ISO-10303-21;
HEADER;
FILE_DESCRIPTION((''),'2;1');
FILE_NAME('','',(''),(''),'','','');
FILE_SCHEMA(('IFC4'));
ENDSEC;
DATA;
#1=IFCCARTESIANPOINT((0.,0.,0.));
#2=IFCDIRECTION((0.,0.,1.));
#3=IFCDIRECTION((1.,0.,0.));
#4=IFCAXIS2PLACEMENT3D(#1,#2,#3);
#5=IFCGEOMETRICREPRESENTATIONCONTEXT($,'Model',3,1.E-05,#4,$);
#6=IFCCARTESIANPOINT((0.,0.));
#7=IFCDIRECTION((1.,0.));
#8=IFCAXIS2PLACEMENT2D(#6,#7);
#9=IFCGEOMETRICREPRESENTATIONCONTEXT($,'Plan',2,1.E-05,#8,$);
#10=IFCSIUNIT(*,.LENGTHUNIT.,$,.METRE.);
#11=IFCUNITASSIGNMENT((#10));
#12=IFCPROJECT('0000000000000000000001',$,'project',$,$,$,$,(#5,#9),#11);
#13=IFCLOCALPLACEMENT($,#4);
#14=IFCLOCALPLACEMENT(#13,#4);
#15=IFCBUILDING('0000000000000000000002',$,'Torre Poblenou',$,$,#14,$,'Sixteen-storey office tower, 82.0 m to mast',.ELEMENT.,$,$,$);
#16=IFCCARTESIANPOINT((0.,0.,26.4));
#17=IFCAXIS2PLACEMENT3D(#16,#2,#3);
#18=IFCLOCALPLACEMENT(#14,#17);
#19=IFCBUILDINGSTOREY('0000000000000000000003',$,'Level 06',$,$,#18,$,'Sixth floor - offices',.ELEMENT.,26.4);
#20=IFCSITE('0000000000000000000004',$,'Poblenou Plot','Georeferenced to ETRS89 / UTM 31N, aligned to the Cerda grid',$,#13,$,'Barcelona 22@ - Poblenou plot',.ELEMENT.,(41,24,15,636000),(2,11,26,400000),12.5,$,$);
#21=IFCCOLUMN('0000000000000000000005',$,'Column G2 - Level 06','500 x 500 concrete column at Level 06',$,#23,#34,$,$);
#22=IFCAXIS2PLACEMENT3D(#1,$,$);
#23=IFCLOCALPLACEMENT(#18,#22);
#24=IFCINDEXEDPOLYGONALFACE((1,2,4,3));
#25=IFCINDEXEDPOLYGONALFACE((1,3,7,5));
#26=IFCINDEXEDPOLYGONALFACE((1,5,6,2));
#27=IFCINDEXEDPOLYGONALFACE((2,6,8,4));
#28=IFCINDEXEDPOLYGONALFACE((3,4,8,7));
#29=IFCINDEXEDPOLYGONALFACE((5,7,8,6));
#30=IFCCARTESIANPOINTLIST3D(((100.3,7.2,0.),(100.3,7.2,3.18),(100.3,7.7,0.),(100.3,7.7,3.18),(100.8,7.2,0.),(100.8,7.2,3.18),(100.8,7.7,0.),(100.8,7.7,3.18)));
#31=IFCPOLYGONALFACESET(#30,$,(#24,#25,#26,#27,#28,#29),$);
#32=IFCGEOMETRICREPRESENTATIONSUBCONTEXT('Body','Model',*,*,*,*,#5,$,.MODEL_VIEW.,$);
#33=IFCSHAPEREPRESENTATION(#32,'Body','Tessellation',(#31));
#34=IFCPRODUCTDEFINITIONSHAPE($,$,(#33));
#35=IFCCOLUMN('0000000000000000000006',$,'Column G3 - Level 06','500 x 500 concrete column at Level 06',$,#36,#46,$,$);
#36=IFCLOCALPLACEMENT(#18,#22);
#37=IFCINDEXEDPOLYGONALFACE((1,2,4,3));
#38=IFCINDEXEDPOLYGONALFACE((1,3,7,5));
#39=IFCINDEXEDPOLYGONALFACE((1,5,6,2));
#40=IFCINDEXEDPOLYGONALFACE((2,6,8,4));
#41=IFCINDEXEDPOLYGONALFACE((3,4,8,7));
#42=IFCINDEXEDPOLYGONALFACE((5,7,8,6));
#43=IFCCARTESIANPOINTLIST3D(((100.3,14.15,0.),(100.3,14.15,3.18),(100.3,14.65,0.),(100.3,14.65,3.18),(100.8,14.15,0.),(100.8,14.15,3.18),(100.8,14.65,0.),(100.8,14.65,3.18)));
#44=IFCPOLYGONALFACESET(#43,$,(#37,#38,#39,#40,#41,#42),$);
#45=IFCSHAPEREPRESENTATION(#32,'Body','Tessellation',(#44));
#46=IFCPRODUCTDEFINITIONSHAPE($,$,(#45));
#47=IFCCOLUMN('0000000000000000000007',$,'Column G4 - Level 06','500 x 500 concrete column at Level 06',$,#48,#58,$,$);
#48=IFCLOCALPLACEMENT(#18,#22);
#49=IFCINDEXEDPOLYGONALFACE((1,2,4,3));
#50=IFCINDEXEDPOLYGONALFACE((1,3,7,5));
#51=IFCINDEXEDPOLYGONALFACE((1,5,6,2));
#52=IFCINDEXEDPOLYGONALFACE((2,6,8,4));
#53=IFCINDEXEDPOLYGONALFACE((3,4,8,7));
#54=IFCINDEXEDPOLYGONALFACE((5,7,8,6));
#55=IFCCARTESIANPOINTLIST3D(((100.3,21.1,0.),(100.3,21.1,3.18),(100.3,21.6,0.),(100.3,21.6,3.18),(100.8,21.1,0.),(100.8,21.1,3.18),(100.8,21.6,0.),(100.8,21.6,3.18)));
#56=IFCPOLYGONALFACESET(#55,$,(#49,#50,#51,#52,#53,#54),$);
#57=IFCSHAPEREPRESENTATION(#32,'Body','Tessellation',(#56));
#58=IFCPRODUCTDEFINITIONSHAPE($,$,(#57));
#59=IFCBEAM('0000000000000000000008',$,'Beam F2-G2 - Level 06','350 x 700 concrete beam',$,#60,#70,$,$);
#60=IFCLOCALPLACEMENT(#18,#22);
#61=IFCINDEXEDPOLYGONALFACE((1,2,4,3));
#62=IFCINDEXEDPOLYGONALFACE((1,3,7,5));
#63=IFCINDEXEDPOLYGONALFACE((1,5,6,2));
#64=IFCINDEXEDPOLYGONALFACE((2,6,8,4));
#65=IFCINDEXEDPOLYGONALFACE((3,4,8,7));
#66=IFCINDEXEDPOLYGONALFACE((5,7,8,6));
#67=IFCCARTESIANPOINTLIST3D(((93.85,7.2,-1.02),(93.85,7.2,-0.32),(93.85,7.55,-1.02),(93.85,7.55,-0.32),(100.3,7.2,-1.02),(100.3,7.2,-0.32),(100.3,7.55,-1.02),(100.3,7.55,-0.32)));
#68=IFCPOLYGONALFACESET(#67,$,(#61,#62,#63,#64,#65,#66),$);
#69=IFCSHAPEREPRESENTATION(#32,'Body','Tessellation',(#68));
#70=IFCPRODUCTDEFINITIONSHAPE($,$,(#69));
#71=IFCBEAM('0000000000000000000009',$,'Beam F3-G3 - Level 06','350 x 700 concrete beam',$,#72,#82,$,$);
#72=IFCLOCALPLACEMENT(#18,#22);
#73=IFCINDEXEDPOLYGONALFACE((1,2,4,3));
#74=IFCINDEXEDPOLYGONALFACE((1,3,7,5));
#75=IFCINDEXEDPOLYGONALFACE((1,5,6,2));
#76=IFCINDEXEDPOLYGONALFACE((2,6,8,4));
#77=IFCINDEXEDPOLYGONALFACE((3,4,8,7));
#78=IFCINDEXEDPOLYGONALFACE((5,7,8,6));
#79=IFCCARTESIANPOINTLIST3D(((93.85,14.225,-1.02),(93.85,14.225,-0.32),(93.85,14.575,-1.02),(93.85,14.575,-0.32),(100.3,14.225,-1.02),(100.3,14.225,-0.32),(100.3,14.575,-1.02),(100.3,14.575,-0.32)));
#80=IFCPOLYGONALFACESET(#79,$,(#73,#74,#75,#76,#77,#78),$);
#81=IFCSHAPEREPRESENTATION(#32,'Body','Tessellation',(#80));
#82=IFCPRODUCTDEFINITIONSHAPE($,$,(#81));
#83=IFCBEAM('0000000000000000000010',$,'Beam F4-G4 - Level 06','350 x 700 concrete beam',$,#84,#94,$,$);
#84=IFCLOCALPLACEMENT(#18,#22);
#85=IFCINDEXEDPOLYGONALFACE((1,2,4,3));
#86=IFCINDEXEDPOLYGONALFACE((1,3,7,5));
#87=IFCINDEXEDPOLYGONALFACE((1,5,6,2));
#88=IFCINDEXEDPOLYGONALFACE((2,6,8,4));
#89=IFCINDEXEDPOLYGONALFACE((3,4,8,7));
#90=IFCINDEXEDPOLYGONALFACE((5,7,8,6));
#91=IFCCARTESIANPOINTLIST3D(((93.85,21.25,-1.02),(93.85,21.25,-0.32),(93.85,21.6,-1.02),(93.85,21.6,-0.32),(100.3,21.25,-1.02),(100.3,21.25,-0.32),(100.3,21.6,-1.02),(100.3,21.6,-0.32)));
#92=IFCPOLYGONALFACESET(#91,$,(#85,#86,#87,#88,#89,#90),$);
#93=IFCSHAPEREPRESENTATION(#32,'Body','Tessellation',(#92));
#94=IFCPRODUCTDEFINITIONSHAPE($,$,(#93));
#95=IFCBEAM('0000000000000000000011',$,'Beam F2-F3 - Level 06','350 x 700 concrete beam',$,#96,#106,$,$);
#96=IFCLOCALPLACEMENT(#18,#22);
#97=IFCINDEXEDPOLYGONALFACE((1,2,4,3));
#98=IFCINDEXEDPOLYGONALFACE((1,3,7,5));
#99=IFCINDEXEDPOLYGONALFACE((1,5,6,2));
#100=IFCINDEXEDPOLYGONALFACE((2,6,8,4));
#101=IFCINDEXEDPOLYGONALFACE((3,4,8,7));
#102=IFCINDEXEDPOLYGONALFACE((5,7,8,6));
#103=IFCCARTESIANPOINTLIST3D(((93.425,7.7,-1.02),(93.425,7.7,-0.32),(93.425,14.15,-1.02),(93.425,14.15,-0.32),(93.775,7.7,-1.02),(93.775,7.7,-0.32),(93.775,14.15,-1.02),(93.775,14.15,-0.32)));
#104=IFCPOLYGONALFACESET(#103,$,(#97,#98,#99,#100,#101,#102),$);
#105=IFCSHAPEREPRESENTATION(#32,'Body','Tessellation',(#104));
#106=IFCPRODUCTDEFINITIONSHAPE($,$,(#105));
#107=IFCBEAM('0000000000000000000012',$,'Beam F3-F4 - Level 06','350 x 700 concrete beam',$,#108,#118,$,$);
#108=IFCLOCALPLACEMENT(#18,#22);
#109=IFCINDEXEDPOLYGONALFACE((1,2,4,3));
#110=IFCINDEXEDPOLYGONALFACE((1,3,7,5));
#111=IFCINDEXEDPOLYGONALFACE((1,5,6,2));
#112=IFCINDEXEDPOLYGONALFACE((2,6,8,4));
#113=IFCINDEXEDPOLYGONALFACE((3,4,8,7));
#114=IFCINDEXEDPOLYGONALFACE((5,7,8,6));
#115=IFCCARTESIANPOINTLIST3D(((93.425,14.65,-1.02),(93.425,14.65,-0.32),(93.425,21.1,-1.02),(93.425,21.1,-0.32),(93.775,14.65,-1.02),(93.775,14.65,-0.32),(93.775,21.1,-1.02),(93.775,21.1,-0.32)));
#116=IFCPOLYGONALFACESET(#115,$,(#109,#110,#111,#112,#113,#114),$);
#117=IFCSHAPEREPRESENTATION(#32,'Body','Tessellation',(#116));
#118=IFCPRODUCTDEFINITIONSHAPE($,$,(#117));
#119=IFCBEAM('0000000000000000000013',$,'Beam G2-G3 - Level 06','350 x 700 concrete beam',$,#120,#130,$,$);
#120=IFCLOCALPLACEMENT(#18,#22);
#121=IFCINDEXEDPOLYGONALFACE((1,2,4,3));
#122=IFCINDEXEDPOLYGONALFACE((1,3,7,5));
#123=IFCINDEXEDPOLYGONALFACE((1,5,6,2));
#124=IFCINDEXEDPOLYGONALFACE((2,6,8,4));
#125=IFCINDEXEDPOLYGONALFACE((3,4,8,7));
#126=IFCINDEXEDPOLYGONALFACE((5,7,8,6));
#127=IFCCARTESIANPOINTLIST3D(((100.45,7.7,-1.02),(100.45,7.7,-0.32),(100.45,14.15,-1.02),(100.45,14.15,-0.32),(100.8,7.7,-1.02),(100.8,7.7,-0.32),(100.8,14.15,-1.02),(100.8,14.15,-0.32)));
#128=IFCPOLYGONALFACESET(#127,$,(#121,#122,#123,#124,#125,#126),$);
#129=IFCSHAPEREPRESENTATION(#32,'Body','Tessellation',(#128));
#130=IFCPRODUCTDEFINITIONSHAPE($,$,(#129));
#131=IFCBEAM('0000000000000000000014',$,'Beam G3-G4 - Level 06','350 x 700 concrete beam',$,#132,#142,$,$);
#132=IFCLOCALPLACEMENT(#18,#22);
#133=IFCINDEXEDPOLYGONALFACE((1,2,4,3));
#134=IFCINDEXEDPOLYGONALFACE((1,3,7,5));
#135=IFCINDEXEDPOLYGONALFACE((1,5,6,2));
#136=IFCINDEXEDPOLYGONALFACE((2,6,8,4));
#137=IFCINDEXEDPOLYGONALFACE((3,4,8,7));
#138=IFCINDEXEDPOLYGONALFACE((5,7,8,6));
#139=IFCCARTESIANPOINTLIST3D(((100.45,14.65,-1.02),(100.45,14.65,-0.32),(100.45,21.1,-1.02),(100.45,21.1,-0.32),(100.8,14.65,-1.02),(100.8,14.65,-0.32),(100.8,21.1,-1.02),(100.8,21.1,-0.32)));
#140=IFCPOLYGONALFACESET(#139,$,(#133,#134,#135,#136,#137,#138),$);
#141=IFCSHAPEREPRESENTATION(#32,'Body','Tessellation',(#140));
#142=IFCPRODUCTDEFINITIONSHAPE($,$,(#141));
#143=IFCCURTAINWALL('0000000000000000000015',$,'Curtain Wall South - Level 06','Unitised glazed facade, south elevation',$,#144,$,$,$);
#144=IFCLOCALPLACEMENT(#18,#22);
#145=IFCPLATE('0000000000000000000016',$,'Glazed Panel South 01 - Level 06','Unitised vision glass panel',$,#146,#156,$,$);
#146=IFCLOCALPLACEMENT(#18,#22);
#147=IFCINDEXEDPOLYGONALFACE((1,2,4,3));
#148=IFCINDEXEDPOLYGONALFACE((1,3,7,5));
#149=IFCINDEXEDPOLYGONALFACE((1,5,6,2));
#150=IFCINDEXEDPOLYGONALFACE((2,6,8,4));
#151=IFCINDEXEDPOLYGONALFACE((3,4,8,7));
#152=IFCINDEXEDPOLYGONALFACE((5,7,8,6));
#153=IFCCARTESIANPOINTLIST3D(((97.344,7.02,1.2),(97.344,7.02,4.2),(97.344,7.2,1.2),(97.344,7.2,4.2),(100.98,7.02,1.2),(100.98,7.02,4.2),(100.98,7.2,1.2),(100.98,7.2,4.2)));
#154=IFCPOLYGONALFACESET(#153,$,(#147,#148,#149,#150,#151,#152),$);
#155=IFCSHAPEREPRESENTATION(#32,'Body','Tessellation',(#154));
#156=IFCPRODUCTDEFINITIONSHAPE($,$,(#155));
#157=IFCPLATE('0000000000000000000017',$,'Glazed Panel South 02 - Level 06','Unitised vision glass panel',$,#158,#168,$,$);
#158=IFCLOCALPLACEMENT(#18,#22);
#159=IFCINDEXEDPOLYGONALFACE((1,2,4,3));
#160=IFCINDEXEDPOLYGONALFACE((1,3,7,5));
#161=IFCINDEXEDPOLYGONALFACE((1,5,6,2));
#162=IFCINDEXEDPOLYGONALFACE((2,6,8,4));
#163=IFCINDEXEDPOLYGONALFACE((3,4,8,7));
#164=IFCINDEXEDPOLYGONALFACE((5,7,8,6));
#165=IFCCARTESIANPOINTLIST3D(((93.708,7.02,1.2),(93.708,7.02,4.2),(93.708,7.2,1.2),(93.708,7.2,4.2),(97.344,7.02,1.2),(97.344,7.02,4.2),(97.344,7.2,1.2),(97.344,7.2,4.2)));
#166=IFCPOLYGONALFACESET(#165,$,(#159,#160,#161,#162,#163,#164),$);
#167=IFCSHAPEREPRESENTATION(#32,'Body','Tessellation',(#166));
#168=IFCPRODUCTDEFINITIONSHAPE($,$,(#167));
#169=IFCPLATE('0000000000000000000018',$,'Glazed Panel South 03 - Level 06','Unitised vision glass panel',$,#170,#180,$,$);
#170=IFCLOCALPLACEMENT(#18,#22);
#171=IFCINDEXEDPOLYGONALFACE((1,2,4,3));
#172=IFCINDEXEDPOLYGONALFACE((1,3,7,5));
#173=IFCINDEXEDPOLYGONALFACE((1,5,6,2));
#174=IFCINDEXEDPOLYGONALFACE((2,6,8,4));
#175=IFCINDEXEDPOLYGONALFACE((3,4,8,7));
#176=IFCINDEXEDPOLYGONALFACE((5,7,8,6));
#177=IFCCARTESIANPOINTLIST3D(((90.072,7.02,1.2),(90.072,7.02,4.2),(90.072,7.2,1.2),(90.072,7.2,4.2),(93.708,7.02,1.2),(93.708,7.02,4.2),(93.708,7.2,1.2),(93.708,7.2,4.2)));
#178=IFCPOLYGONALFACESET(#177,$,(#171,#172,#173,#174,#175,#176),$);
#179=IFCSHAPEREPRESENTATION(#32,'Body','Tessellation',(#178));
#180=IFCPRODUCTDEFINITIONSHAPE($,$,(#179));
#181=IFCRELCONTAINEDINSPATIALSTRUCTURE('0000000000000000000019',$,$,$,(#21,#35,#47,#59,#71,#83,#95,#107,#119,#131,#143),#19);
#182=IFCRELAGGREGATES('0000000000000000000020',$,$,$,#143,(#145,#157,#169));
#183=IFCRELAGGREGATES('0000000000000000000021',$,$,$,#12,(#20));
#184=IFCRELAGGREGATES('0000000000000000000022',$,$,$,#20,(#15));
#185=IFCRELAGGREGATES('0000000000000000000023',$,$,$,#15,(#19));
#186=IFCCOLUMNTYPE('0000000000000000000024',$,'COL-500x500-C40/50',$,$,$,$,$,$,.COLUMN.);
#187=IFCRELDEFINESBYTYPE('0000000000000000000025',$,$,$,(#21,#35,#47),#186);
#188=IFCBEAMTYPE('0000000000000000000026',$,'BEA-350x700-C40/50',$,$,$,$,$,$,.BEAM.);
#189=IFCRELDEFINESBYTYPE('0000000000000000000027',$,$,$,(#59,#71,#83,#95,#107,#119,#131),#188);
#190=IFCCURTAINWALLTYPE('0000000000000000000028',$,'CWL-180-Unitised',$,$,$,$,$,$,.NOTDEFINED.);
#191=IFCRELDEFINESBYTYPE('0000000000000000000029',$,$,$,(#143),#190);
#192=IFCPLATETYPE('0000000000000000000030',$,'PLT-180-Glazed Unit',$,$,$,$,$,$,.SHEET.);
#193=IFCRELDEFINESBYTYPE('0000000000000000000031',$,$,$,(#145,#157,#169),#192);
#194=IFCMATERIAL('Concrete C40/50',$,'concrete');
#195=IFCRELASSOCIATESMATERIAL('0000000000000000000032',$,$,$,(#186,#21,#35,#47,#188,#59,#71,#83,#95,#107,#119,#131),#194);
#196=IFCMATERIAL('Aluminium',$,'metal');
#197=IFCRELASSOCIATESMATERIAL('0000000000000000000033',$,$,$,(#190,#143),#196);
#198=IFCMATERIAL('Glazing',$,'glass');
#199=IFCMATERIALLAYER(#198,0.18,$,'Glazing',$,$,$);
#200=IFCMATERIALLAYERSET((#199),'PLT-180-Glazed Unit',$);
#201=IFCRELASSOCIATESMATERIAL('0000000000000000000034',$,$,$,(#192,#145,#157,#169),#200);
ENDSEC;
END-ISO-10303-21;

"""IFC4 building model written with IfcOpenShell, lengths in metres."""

from ifc_helpers import new_model, si_unit, frame, origin_with_axes, origin_2d_with_axis, place, context, subcontext, project, spatial, line, indexed_curve, rectangle, outline, extrude, material, layer, layer_set, layer_usage, material_profile, profile_set, profile_usage, type_object, element, aggregate, save


model = new_model("IFC4")

# Units and contexts
model_context = context("Model", 3, precision=1e-05, world=origin_with_axes())
plan_context = context("Plan", 2, precision=1e-05, world=origin_2d_with_axis())
body_context = subcontext(model_context, "Body", "Model", "MODEL_VIEW")
ifc_project = project(units=[si_unit("LENGTHUNIT", "METRE")], contexts=[model_context, plan_context])

# Site, building, storey
site_placement = place(None, origin_with_axes())
site = spatial("IfcSite", under=ifc_project, at=site_placement, Name="Poblenou Plot", Description="Georeferenced to ETRS89 / UTM 31N, aligned to the Cerda grid", LongName="Barcelona 22@ - Poblenou plot", CompositionType="ELEMENT", RefLatitude=(41, 24, 15, 636000), RefLongitude=(2, 11, 26, 400000), RefElevation=12.5)
building_placement = place(site_placement, origin_with_axes())
building = spatial("IfcBuilding", under=site, at=building_placement, Name="Torre Poblenou", LongName="Sixteen-storey office tower, 82.0 m to mast", CompositionType="ELEMENT")
storey_placement = place(building_placement, frame((0.0, 0.0, 26.4), z_axis=(0.0, 0.0, 1.0), x_axis=(1.0, 0.0, 0.0)))
storey = spatial("IfcBuildingStorey", under=building, at=storey_placement, Name="Level 06", LongName="Sixth floor - offices", CompositionType="ELEMENT", Elevation=26.4)

# Columns
ifc_material_1 = material(Name="Concrete C40/50", Category="concrete")
ifc_material_profile_1 = material_profile(ifc_material_1, rectangle(XDim=0.5, YDim=0.5))
ifc_profile_set_1 = profile_set([ifc_material_profile_1], Name="COL-500x500-C40/50")
ifc_profile_usage_1 = profile_usage(ifc_profile_set_1)
column_type = type_object("IfcColumnType", Name="COL-500x500-C40/50", PredefinedType="COLUMN", material=ifc_profile_set_1)
column_1_placement = place(storey_placement, frame((100.3, 7.2, 0.0), z_axis=(0.0, 0.0, 1.0), x_axis=(1.0, 0.0, 0.0)))
element("IfcColumn", 1, at=column_1_placement, inside=storey, type_object=column_type, material=ifc_profile_usage_1, Name="Column G2 - Level 06", Description="500 x 500 concrete column at Level 06", context=body_context, shape_type="SweptSolid", body=[
    extrude(outline(indexed_curve([(0.0, 0.0), (0.5, 0.0), (0.5, 0.5), (0.0, 0.5)], segments=[line(1, 2, 3, 4, 1)])), origin_with_axes(), (0.0, 0.0, 1.0), 3.18),
])
ifc_profile_usage_2 = profile_usage(ifc_profile_set_1)
column_2_placement = place(storey_placement, frame((100.3, 14.15, 0.0), z_axis=(0.0, 0.0, 1.0), x_axis=(1.0, 0.0, 0.0)))
element("IfcColumn", 2, at=column_2_placement, inside=storey, type_object=column_type, material=ifc_profile_usage_2, Name="Column G3 - Level 06", Description="500 x 500 concrete column at Level 06", context=body_context, shape_type="SweptSolid", body=[
    extrude(outline(indexed_curve([(0.0, 0.0), (0.5, 0.0), (0.5, 0.5), (0.0, 0.5)], segments=[line(1, 2, 3, 4, 1)])), origin_with_axes(), (0.0, 0.0, 1.0), 3.18),
])
ifc_profile_usage_3 = profile_usage(ifc_profile_set_1)
column_3_placement = place(storey_placement, frame((100.3, 21.1, 0.0), z_axis=(0.0, 0.0, 1.0), x_axis=(1.0, 0.0, 0.0)))
element("IfcColumn", 3, at=column_3_placement, inside=storey, type_object=column_type, material=ifc_profile_usage_3, Name="Column G4 - Level 06", Description="500 x 500 concrete column at Level 06", context=body_context, shape_type="SweptSolid", body=[
    extrude(outline(indexed_curve([(0.0, 0.0), (0.5, 0.0), (0.5, 0.5), (0.0, 0.5)], segments=[line(1, 2, 3, 4, 1)])), origin_with_axes(), (0.0, 0.0, 1.0), 3.18),
])

# Beams
ifc_material_profile_2 = material_profile(ifc_material_1, rectangle(XDim=0.35, YDim=0.7))
ifc_profile_set_2 = profile_set([ifc_material_profile_2], Name="BEA-350x700-C40/50")
ifc_profile_usage_4 = profile_usage(ifc_profile_set_2)
beam_type = type_object("IfcBeamType", Name="BEA-350x700-C40/50", PredefinedType="BEAM", material=ifc_profile_set_2)
beam_1_placement = place(storey_placement, frame((93.85, 7.2, -1.02), z_axis=(0.0, 0.0, 1.0), x_axis=(1.0, 0.0, 0.0)))
element("IfcBeam", 4, at=beam_1_placement, inside=storey, type_object=beam_type, material=ifc_profile_usage_4, Name="Beam F2-G2 - Level 06", Description="350 x 700 concrete beam", context=body_context, shape_type="SweptSolid", body=[
    extrude(outline(indexed_curve([(0.0, 0.0), (6.45, 0.0), (6.45, 0.35), (0.0, 0.35)], segments=[line(1, 2, 3, 4, 1)])), origin_with_axes(), (0.0, 0.0, 1.0), 0.7),
])
ifc_profile_usage_5 = profile_usage(ifc_profile_set_2)
beam_2_placement = place(storey_placement, frame((93.85, 14.225, -1.02), z_axis=(0.0, 0.0, 1.0), x_axis=(1.0, 0.0, 0.0)))
element("IfcBeam", 5, at=beam_2_placement, inside=storey, type_object=beam_type, material=ifc_profile_usage_5, Name="Beam F3-G3 - Level 06", Description="350 x 700 concrete beam", context=body_context, shape_type="SweptSolid", body=[
    extrude(outline(indexed_curve([(0.0, 0.0), (6.45, 0.0), (6.45, 0.35), (0.0, 0.35)], segments=[line(1, 2, 3, 4, 1)])), origin_with_axes(), (0.0, 0.0, 1.0), 0.7),
])
ifc_profile_usage_6 = profile_usage(ifc_profile_set_2)
beam_3_placement = place(storey_placement, frame((93.85, 21.25, -1.02), z_axis=(0.0, 0.0, 1.0), x_axis=(1.0, 0.0, 0.0)))
element("IfcBeam", 6, at=beam_3_placement, inside=storey, type_object=beam_type, material=ifc_profile_usage_6, Name="Beam F4-G4 - Level 06", Description="350 x 700 concrete beam", context=body_context, shape_type="SweptSolid", body=[
    extrude(outline(indexed_curve([(0.0, 0.0), (6.45, 0.0), (6.45, 0.35), (0.0, 0.35)], segments=[line(1, 2, 3, 4, 1)])), origin_with_axes(), (0.0, 0.0, 1.0), 0.7),
])
ifc_profile_usage_7 = profile_usage(ifc_profile_set_2)
beam_4_placement = place(storey_placement, frame((93.775, 7.7, -1.02), z_axis=(0.0, 0.0, 1.0), x_axis=(0.0, 1.0, 0.0)))
element("IfcBeam", 7, at=beam_4_placement, inside=storey, type_object=beam_type, material=ifc_profile_usage_7, Name="Beam F2-F3 - Level 06", Description="350 x 700 concrete beam", context=body_context, shape_type="SweptSolid", body=[
    extrude(outline(indexed_curve([(0.0, 0.0), (6.45, 0.0), (6.45, 0.35), (0.0, 0.35)], segments=[line(1, 2, 3, 4, 1)])), origin_with_axes(), (0.0, 0.0, 1.0), 0.7),
])
ifc_profile_usage_8 = profile_usage(ifc_profile_set_2)
beam_5_placement = place(storey_placement, frame((93.775, 14.65, -1.02), z_axis=(0.0, 0.0, 1.0), x_axis=(0.0, 1.0, 0.0)))
element("IfcBeam", 8, at=beam_5_placement, inside=storey, type_object=beam_type, material=ifc_profile_usage_8, Name="Beam F3-F4 - Level 06", Description="350 x 700 concrete beam", context=body_context, shape_type="SweptSolid", body=[
    extrude(outline(indexed_curve([(0.0, 0.0), (6.45, 0.0), (6.45, 0.35), (0.0, 0.35)], segments=[line(1, 2, 3, 4, 1)])), origin_with_axes(), (0.0, 0.0, 1.0), 0.7),
])
ifc_profile_usage_9 = profile_usage(ifc_profile_set_2)
beam_6_placement = place(storey_placement, frame((100.8, 7.7, -1.02), z_axis=(0.0, 0.0, 1.0), x_axis=(0.0, 1.0, 0.0)))
element("IfcBeam", 9, at=beam_6_placement, inside=storey, type_object=beam_type, material=ifc_profile_usage_9, Name="Beam G2-G3 - Level 06", Description="350 x 700 concrete beam", context=body_context, shape_type="SweptSolid", body=[
    extrude(outline(indexed_curve([(0.0, 0.0), (6.45, 0.0), (6.45, 0.35), (0.0, 0.35)], segments=[line(1, 2, 3, 4, 1)])), origin_with_axes(), (0.0, 0.0, 1.0), 0.7),
])
ifc_profile_usage_10 = profile_usage(ifc_profile_set_2)
beam_7_placement = place(storey_placement, frame((100.8, 14.65, -1.02), z_axis=(0.0, 0.0, 1.0), x_axis=(0.0, 1.0, 0.0)))
element("IfcBeam", 10, at=beam_7_placement, inside=storey, type_object=beam_type, material=ifc_profile_usage_10, Name="Beam G3-G4 - Level 06", Description="350 x 700 concrete beam", context=body_context, shape_type="SweptSolid", body=[
    extrude(outline(indexed_curve([(0.0, 0.0), (6.45, 0.0), (6.45, 0.35), (0.0, 0.35)], segments=[line(1, 2, 3, 4, 1)])), origin_with_axes(), (0.0, 0.0, 1.0), 0.7),
])

# Curtain wall, plates
ifc_material_2 = material(Name="Aluminium", Category="metal")
curtain_wall_type = type_object("IfcCurtainWallType", Name="CWL-180-Unitised", PredefinedType="NOTDEFINED", material=ifc_material_2)
curtain_wall_1_placement = place(storey_placement, frame((100.98, 7.2, 0.0), z_axis=(0.0, 0.0, 1.0), x_axis=(-1.0, 0.0, 0.0)))
curtain_wall_1 = element("IfcCurtainWall", 11, at=curtain_wall_1_placement, inside=storey, type_object=curtain_wall_type, material=ifc_material_2, Name="Curtain Wall South - Level 06", Description="Unitised glazed facade, south elevation")
ifc_material_3 = material(Name="Glazing", Category="glass")
ifc_layer_1 = layer(ifc_material_3, 0.18, Name="Glazing")
ifc_layer_set_1 = layer_set([ifc_layer_1], Name="PLT-180-Glazed Unit")
ifc_layer_usage_1 = layer_usage(ifc_layer_set_1, "AXIS2", "POSITIVE", 0.0)
plate_type_1 = type_object("IfcPlateType", Name="PLT-180-Glazed Unit", PredefinedType="SHEET", material=ifc_layer_set_1)
plate_1_placement = place(curtain_wall_1_placement, frame((0.0, 0.0, 1.2), z_axis=(0.0, 0.0, 1.0), x_axis=(1.0, 0.0, 0.0)))
plate_1 = element("IfcPlate", 12, at=plate_1_placement, type_object=plate_type_1, material=ifc_layer_usage_1, Name="Glazed Panel South 01 - Level 06", Description="Unitised vision glass panel", context=body_context, shape_type="SweptSolid", body=[
    extrude(outline(indexed_curve([(0.0, 0.0), (3.636, 0.0), (3.636, 0.18), (0.0, 0.18)], segments=[line(1, 2, 3, 4, 1)])), origin_with_axes(), (0.0, 0.0, 1.0), 3.0),
])
ifc_layer_usage_2 = layer_usage(ifc_layer_set_1, "AXIS2", "POSITIVE", 0.0)
plate_2_placement = place(curtain_wall_1_placement, frame((3.636, 0.0, 1.2), z_axis=(0.0, 0.0, 1.0), x_axis=(1.0, 0.0, 0.0)))
plate_2 = element("IfcPlate", 13, at=plate_2_placement, type_object=plate_type_1, material=ifc_layer_usage_2, Name="Glazed Panel South 02 - Level 06", Description="Unitised vision glass panel", context=body_context, shape_type="SweptSolid", body=[
    extrude(outline(indexed_curve([(0.0, 0.0), (3.636, 0.0), (3.636, 0.18), (0.0, 0.18)], segments=[line(1, 2, 3, 4, 1)])), origin_with_axes(), (0.0, 0.0, 1.0), 3.0),
])
ifc_layer_usage_3 = layer_usage(ifc_layer_set_1, "AXIS2", "POSITIVE", 0.0)
plate_3_placement = place(curtain_wall_1_placement, frame((7.272, 0.0, 1.2), z_axis=(0.0, 0.0, 1.0), x_axis=(1.0, 0.0, 0.0)))
plate_3 = element("IfcPlate", 14, at=plate_3_placement, type_object=plate_type_1, material=ifc_layer_usage_3, Name="Glazed Panel South 03 - Level 06", Description="Unitised vision glass panel", context=body_context, shape_type="SweptSolid", body=[
    extrude(outline(indexed_curve([(0.0, 0.0), (3.636, 0.0), (3.636, 0.18), (0.0, 0.18)], segments=[line(1, 2, 3, 4, 1)])), origin_with_axes(), (0.0, 0.0, 1.0), 3.0),
])

aggregate(curtain_wall_1, [plate_1, plate_2, plate_3])

save(model, "model.ifc")
